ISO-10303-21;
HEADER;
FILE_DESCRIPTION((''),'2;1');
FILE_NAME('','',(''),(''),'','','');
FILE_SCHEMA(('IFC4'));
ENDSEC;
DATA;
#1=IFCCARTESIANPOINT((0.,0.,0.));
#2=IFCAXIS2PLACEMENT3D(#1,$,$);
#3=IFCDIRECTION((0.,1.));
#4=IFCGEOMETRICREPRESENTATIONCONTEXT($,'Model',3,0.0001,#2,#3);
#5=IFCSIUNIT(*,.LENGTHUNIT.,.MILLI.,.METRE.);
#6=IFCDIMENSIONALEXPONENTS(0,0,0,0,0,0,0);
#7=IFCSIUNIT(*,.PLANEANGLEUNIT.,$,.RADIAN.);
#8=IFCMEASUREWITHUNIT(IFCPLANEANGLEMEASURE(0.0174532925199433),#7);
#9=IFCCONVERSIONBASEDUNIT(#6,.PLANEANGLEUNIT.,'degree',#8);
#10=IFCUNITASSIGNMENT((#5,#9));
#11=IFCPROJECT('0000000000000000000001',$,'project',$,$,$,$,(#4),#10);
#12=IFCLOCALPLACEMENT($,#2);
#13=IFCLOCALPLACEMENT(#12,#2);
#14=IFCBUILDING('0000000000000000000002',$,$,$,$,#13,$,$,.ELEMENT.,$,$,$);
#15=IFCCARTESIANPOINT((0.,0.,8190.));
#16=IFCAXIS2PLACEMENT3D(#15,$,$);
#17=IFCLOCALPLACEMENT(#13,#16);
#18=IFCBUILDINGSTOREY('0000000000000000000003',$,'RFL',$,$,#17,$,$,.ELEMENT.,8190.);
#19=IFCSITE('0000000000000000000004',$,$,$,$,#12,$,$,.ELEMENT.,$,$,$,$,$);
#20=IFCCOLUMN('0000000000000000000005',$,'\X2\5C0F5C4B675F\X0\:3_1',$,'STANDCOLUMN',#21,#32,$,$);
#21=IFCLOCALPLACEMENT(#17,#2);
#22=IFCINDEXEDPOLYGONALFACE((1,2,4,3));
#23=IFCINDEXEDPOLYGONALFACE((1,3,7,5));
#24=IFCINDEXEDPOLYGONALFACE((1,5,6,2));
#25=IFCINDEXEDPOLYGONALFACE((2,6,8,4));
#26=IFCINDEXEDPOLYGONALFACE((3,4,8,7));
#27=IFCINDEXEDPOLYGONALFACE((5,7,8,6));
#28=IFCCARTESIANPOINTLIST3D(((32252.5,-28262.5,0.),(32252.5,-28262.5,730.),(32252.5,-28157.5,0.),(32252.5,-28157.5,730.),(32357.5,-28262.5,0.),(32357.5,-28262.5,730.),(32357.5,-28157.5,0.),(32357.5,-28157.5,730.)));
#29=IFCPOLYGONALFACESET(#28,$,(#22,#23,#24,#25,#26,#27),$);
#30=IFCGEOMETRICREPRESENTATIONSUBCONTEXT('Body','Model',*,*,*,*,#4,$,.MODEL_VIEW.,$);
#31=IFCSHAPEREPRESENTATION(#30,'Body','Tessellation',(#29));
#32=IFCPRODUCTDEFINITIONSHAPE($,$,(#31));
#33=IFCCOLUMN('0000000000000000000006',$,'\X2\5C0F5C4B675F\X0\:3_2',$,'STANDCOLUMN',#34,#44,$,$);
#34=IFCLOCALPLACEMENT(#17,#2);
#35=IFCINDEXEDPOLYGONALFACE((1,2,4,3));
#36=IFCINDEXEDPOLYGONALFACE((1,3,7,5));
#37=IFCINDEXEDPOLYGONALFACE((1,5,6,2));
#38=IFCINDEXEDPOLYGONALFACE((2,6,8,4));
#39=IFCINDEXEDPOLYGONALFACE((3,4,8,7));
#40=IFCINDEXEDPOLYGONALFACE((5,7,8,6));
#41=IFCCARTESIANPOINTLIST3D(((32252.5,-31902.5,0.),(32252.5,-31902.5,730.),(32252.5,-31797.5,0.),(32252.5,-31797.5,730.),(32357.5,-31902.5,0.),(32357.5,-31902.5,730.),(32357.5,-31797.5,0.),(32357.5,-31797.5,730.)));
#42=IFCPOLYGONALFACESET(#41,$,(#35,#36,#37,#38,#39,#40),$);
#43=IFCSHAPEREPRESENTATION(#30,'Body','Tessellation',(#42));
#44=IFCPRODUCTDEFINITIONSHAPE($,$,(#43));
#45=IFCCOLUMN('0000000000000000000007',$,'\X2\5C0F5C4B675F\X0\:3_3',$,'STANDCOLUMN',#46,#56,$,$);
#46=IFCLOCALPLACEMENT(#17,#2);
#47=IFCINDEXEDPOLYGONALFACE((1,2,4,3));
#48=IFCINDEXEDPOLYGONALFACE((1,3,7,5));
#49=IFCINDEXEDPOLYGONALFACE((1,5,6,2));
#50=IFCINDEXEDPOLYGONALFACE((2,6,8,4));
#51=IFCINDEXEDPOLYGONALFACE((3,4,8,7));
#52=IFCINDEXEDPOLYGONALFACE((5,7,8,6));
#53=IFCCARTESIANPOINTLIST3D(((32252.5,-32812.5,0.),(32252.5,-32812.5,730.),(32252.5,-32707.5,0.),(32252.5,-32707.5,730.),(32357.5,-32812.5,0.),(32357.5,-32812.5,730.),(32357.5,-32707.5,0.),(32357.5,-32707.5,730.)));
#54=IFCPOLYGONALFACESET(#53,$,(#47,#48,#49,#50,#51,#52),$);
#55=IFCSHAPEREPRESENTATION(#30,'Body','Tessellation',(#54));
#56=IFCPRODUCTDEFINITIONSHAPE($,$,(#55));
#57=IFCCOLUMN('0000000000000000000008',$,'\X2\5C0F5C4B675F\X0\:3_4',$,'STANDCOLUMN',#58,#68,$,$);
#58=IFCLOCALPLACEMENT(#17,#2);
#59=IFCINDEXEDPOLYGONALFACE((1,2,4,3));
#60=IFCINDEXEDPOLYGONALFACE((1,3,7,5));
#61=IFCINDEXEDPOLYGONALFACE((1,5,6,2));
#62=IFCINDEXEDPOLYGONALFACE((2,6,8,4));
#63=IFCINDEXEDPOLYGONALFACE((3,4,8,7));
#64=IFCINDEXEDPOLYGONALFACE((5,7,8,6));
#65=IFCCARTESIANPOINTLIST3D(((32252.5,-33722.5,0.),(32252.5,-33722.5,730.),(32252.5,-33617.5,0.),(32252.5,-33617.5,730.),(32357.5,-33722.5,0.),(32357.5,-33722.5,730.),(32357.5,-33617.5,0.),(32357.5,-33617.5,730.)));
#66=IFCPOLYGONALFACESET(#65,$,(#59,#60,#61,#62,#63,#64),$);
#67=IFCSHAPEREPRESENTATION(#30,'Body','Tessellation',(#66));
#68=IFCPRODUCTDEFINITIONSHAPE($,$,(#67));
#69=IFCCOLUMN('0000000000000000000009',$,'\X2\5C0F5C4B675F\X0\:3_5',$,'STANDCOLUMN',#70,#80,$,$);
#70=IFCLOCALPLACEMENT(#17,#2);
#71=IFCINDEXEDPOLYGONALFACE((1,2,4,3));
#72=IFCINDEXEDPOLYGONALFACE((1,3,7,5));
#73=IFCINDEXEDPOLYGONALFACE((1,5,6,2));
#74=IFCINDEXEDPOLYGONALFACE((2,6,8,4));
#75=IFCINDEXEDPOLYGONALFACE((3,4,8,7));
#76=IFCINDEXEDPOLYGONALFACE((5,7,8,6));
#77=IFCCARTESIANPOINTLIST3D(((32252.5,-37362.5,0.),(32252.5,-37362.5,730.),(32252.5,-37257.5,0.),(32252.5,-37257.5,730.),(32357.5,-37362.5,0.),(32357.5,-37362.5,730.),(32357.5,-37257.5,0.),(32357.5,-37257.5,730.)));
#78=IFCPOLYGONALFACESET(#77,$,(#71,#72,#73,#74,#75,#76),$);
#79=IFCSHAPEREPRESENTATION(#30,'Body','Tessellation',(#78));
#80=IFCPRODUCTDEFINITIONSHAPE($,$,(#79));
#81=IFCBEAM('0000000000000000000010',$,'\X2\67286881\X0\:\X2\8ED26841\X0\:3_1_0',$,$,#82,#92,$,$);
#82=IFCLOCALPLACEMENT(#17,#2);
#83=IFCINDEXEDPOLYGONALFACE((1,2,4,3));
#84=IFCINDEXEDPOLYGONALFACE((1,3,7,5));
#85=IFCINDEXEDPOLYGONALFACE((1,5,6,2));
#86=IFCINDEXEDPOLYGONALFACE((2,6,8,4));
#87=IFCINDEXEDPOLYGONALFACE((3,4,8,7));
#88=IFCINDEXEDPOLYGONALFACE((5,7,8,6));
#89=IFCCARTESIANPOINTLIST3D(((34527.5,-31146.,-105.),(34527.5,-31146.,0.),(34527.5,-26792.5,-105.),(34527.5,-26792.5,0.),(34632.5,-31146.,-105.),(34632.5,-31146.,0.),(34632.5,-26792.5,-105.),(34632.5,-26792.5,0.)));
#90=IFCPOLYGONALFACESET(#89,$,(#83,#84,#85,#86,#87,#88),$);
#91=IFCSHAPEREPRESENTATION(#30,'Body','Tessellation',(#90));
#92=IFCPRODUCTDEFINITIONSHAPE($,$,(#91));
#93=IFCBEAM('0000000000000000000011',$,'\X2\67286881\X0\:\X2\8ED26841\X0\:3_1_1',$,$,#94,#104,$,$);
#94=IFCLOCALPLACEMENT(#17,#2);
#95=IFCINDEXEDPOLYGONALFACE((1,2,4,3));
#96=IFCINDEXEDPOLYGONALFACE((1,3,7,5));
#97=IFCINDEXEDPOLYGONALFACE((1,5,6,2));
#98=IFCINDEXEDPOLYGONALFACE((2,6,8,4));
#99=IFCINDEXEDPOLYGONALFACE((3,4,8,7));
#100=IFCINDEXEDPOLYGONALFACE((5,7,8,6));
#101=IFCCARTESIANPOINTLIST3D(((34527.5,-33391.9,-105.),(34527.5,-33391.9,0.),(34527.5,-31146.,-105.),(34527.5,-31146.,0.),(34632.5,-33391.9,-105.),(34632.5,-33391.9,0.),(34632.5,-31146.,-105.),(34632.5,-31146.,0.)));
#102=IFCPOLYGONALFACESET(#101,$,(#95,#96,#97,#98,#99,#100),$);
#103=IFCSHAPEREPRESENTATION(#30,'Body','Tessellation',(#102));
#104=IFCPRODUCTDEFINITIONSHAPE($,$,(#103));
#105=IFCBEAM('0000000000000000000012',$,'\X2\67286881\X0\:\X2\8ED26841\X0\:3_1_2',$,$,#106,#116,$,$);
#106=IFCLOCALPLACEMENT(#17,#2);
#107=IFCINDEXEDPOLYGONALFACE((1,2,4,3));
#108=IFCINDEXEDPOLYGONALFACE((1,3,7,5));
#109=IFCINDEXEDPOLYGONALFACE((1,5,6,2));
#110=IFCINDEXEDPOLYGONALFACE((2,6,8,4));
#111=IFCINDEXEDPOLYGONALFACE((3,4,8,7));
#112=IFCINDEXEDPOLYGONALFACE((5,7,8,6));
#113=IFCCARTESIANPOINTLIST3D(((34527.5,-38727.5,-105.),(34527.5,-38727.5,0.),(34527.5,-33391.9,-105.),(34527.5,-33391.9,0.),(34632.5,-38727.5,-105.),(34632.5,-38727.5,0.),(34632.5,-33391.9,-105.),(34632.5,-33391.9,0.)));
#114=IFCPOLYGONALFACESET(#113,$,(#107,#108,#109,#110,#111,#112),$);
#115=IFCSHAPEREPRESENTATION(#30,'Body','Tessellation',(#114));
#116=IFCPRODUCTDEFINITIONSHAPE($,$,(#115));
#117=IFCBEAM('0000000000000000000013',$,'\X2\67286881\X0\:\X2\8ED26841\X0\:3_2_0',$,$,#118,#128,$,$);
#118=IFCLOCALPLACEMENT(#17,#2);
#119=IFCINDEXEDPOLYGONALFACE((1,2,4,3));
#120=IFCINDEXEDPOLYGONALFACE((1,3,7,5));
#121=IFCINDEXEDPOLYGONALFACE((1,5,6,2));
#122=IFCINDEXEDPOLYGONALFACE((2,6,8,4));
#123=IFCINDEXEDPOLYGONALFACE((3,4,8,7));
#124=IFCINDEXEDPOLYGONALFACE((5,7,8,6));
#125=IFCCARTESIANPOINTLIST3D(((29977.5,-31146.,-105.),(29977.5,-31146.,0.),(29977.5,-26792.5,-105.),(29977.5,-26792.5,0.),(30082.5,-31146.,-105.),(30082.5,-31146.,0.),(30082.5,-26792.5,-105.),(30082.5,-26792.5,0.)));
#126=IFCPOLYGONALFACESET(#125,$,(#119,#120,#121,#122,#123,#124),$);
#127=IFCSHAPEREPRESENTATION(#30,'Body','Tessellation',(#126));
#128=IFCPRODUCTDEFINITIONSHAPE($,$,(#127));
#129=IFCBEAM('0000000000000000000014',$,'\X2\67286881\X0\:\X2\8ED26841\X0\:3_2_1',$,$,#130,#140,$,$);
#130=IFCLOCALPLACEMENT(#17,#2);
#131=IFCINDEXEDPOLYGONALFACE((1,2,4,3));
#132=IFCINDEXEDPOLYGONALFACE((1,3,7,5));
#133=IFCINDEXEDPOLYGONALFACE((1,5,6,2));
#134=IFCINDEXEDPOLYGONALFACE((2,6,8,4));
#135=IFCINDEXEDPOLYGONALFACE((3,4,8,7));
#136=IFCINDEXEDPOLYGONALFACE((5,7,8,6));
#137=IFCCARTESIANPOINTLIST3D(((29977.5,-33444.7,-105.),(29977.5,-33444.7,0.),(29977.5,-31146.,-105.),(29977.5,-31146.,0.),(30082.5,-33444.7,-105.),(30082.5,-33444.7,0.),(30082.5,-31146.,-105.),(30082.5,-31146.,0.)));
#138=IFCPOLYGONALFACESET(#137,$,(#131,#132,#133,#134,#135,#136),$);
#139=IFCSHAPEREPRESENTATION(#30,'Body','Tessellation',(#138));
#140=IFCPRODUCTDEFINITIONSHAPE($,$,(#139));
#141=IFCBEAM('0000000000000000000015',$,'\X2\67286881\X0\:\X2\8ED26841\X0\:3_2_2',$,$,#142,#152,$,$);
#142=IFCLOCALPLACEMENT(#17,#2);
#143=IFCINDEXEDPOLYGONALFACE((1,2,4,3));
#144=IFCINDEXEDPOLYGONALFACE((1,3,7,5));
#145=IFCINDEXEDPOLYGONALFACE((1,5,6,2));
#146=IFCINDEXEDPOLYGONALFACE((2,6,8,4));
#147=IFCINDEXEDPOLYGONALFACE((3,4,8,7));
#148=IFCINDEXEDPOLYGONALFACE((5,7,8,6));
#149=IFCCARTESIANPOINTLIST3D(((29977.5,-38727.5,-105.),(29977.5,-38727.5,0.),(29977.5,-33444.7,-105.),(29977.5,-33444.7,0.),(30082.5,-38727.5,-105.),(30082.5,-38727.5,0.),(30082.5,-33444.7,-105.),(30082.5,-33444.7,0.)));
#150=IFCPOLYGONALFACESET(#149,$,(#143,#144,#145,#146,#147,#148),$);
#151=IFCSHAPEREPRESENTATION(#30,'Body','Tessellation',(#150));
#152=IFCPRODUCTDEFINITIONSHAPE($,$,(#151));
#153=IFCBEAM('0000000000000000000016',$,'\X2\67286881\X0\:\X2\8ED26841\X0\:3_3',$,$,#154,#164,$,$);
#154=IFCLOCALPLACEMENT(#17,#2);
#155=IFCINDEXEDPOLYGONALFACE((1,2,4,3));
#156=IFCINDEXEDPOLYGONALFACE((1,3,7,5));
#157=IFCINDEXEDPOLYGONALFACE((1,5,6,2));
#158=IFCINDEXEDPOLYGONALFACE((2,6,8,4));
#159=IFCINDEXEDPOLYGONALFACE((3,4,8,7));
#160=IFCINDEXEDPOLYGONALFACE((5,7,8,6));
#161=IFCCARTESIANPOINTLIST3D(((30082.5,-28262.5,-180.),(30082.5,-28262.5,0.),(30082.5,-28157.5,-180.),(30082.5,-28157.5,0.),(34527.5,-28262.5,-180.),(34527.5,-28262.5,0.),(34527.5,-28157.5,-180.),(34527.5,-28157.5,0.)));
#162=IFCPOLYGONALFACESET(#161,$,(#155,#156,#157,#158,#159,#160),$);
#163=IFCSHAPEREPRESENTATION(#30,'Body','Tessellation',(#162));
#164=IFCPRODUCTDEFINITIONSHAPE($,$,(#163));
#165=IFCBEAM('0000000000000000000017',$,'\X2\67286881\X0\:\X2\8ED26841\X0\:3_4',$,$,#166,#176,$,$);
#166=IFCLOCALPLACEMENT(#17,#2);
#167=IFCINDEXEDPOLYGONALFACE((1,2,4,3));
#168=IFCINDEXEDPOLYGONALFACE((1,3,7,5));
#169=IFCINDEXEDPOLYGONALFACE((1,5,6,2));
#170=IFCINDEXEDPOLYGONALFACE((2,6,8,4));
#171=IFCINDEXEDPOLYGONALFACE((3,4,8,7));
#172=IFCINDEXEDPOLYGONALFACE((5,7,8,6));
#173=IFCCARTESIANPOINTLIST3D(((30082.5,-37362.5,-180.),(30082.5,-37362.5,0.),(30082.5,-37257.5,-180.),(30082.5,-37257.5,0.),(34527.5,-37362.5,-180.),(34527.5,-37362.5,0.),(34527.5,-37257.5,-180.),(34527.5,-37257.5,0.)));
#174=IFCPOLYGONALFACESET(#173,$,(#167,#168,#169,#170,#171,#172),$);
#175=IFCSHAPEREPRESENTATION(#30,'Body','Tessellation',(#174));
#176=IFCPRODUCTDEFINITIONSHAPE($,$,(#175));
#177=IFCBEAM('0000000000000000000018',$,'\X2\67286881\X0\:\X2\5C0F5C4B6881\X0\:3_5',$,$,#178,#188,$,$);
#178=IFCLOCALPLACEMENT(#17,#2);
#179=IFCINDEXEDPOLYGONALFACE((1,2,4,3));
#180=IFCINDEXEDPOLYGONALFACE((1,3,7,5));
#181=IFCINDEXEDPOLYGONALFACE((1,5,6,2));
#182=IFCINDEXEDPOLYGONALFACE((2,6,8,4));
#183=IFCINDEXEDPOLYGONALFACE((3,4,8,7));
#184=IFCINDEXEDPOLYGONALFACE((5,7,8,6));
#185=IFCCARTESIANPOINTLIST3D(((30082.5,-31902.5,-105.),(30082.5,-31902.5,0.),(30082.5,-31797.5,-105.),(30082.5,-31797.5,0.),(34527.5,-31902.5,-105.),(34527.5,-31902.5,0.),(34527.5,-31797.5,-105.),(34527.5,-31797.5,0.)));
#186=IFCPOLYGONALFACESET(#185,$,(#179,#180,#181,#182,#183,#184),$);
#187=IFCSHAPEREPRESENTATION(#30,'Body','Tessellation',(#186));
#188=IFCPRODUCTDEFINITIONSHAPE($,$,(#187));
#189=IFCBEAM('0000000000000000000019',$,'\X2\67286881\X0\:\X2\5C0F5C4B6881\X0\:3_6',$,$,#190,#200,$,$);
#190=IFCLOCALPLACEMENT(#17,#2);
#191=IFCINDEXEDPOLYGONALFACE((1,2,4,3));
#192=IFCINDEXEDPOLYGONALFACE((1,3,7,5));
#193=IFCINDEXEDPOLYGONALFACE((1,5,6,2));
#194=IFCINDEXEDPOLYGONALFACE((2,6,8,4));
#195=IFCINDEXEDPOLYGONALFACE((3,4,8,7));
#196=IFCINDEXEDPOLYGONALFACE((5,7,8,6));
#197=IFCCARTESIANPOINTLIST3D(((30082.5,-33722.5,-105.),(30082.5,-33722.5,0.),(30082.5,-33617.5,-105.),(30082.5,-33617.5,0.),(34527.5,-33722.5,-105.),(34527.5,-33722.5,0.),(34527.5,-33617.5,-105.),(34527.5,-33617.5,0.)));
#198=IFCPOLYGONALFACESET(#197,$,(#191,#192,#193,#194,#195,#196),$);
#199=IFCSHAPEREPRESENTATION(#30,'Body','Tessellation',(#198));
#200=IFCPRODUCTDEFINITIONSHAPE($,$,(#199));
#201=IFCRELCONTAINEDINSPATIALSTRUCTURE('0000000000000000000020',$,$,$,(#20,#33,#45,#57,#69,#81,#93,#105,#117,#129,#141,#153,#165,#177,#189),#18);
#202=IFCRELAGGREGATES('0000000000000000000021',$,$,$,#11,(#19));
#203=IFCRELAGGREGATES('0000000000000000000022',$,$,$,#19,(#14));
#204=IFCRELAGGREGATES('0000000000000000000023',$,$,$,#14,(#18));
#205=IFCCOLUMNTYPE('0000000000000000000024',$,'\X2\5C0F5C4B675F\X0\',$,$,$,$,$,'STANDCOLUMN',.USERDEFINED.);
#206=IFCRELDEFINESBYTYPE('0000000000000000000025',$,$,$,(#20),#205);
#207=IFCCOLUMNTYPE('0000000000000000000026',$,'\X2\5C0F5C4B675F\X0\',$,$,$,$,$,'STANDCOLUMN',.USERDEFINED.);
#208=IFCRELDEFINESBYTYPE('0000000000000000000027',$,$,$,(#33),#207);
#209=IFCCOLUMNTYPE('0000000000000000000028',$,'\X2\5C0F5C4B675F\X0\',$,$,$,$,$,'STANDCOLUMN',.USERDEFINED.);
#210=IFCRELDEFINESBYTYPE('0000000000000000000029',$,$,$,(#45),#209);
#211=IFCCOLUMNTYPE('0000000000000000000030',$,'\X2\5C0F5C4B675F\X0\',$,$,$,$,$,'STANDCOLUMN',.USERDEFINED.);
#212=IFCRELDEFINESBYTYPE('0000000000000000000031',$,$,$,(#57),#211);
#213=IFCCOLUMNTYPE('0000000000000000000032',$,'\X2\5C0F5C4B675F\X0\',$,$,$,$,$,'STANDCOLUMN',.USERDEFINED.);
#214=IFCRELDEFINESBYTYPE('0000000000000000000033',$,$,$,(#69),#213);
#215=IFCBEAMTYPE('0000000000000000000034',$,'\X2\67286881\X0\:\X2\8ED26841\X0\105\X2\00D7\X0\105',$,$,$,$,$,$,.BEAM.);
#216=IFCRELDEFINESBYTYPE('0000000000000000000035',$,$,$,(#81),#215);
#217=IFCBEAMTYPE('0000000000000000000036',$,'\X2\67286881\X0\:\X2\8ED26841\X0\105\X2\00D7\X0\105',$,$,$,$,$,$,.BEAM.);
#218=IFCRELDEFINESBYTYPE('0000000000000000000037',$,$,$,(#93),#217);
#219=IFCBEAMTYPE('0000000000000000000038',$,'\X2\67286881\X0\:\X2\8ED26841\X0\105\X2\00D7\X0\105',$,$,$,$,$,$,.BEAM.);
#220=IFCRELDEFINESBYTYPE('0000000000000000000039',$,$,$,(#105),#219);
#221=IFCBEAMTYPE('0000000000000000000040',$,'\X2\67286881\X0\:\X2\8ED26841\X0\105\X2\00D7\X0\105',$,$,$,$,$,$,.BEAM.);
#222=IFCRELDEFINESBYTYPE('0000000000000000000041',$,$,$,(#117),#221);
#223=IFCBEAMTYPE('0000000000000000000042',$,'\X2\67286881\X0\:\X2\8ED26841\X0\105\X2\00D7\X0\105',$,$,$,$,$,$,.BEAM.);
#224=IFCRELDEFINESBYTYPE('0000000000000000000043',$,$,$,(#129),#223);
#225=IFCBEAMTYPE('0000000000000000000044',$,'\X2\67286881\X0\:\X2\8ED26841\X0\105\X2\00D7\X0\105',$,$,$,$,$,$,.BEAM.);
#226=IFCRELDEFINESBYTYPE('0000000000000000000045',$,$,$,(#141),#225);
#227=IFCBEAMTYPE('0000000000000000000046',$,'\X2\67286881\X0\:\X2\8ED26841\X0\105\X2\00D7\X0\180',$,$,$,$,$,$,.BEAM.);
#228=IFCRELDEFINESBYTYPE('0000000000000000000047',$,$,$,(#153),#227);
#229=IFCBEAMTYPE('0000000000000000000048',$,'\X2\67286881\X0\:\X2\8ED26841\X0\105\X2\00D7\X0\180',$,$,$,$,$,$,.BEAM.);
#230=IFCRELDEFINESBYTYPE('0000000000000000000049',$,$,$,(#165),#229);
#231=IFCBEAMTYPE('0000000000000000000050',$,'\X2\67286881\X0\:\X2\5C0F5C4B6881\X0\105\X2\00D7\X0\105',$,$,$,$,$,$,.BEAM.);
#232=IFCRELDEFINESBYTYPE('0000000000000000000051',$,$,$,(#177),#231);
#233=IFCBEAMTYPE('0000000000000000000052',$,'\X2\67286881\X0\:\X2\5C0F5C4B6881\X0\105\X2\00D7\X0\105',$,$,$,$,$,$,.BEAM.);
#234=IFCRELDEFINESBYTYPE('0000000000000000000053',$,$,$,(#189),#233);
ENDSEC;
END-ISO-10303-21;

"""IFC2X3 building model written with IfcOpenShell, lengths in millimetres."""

from ifc_helpers import new_model, entity, si_unit, converted_unit, direction, frame, origin, origin_with_axes, origin_2d, place, context, subcontext, project, spatial, rectangle, extrude, type_object, element, save


model = new_model("IFC2X3")

# Units and contexts
model_context = context("Model", 3, precision=0.0001, world=origin(), true_north=direction((0.0, 1.0)))
body_context = subcontext(model_context, "Body", "Model", "MODEL_VIEW")
ifc_project = project(units=[si_unit("LENGTHUNIT", "METRE", prefix="MILLI"), converted_unit("PLANEANGLEUNIT", "degree", entity("IfcPlaneAngleMeasure", 0.0174532925199433), si_unit("PLANEANGLEUNIT", "RADIAN"), dimensions=[0, 0, 0, 0, 0, 0, 0])], contexts=[model_context])

# Site, building, storey
site_placement = place(None, origin())
site = spatial("IfcSite", under=ifc_project, at=site_placement, CompositionType="ELEMENT")
building_placement = place(site_placement, origin())
building = spatial("IfcBuilding", under=site, at=building_placement, CompositionType="ELEMENT")
storey_placement = place(building_placement, frame((0.0, 0.0, 8190.0)))
storey = spatial("IfcBuildingStorey", under=building, at=storey_placement, Name="RFL", CompositionType="ELEMENT", Elevation=8190.0)

# Columns
column_type_1 = type_object("IfcColumnType", Name="小屋束", ElementType="STANDCOLUMN", PredefinedType="USERDEFINED")
column_1_placement = place(storey_placement, frame((32305.0, -28210.0, 0.0)))
element("IfcColumn", 1, at=column_1_placement, inside=storey, type_object=column_type_1, Name="小屋束:3_1", ObjectType="STANDCOLUMN", context=body_context, shape_type="SweptSolid", body=[
    extrude(rectangle(XDim=105.0, YDim=105.0, at=origin_2d()), origin_with_axes(), (0.0, 0.0, 1.0), 730.0),
])
column_type_2 = type_object("IfcColumnType", Name="小屋束", ElementType="STANDCOLUMN", PredefinedType="USERDEFINED")
column_2_placement = place(storey_placement, frame((32305.0, -31850.0, 0.0)))
element("IfcColumn", 2, at=column_2_placement, inside=storey, type_object=column_type_2, Name="小屋束:3_2", ObjectType="STANDCOLUMN", context=body_context, shape_type="SweptSolid", body=[
    extrude(rectangle(XDim=105.0, YDim=105.0, at=origin_2d()), origin_with_axes(), (0.0, 0.0, 1.0), 730.0),
])
column_type_3 = type_object("IfcColumnType", Name="小屋束", ElementType="STANDCOLUMN", PredefinedType="USERDEFINED")
column_3_placement = place(storey_placement, frame((32305.0, -32760.0, 0.0)))
element("IfcColumn", 3, at=column_3_placement, inside=storey, type_object=column_type_3, Name="小屋束:3_3", ObjectType="STANDCOLUMN", context=body_context, shape_type="SweptSolid", body=[
    extrude(rectangle(XDim=105.0, YDim=105.0, at=origin_2d()), origin_with_axes(), (0.0, 0.0, 1.0), 730.0),
])
column_type_4 = type_object("IfcColumnType", Name="小屋束", ElementType="STANDCOLUMN", PredefinedType="USERDEFINED")
column_4_placement = place(storey_placement, frame((32305.0, -33670.0, 0.0)))
element("IfcColumn", 4, at=column_4_placement, inside=storey, type_object=column_type_4, Name="小屋束:3_4", ObjectType="STANDCOLUMN", context=body_context, shape_type="SweptSolid", body=[
    extrude(rectangle(XDim=105.0, YDim=105.0, at=origin_2d()), origin_with_axes(), (0.0, 0.0, 1.0), 730.0),
])
column_type_5 = type_object("IfcColumnType", Name="小屋束", ElementType="STANDCOLUMN", PredefinedType="USERDEFINED")
column_5_placement = place(storey_placement, frame((32305.0, -37310.0, 0.0)))
element("IfcColumn", 5, at=column_5_placement, inside=storey, type_object=column_type_5, Name="小屋束:3_5", ObjectType="STANDCOLUMN", context=body_context, shape_type="SweptSolid", body=[
    extrude(rectangle(XDim=105.0, YDim=105.0, at=origin_2d()), origin_with_axes(), (0.0, 0.0, 1.0), 730.0),
])

# Beams
beam_type_1 = type_object("IfcBeamType", Name="木梁:軒桁105×105", PredefinedType="BEAM")
beam_1_placement = place(storey_placement, frame((34580.0, -26792.5, -52.5), z_axis=(0.0, -1.0, 0.0), x_axis=(1.0, 0.0, 0.0)))
element("IfcBeam", 6, at=beam_1_placement, inside=storey, type_object=beam_type_1, Name="木梁:軒桁:3_1_0", context=body_context, shape_type="SweptSolid", body=[
    extrude(rectangle(XDim=105.0, YDim=105.0, at=origin_2d()), origin_with_axes(), (0.0, 0.0, 1.0), 4353.5),
])
beam_type_2 = type_object("IfcBeamType", Name="木梁:軒桁105×105", PredefinedType="BEAM")
beam_2_placement = place(storey_placement, frame((34580.0, -31146.0, -52.5), z_axis=(0.0, -1.0, 0.0), x_axis=(1.0, 0.0, 0.0)))
element("IfcBeam", 7, at=beam_2_placement, inside=storey, type_object=beam_type_2, Name="木梁:軒桁:3_1_1", context=body_context, shape_type="SweptSolid", body=[
    extrude(rectangle(XDim=105.0, YDim=105.0, at=origin_2d()), origin_with_axes(), (0.0, 0.0, 1.0), 2245.9),
])
beam_type_3 = type_object("IfcBeamType", Name="木梁:軒桁105×105", PredefinedType="BEAM")
beam_3_placement = place(storey_placement, frame((34580.0, -33391.9, -52.5), z_axis=(0.0, -1.0, 0.0), x_axis=(1.0, 0.0, 0.0)))
element("IfcBeam", 8, at=beam_3_placement, inside=storey, type_object=beam_type_3, Name="木梁:軒桁:3_1_2", context=body_context, shape_type="SweptSolid", body=[
    extrude(rectangle(XDim=105.0, YDim=105.0, at=origin_2d()), origin_with_axes(), (0.0, 0.0, 1.0), 5335.6),
])
beam_type_4 = type_object("IfcBeamType", Name="木梁:軒桁105×105", PredefinedType="BEAM")
beam_4_placement = place(storey_placement, frame((30030.0, -26792.5, -52.5), z_axis=(0.0, -1.0, 0.0), x_axis=(1.0, 0.0, 0.0)))
element("IfcBeam", 9, at=beam_4_placement, inside=storey, type_object=beam_type_4, Name="木梁:軒桁:3_2_0", context=body_context, shape_type="SweptSolid", body=[
    extrude(rectangle(XDim=105.0, YDim=105.0, at=origin_2d()), origin_with_axes(), (0.0, 0.0, 1.0), 4353.5),
])
beam_type_5 = type_object("IfcBeamType", Name="木梁:軒桁105×105", PredefinedType="BEAM")
beam_5_placement = place(storey_placement, frame((30030.0, -31146.0, -52.5), z_axis=(0.0, -1.0, 0.0), x_axis=(1.0, 0.0, 0.0)))
element("IfcBeam", 10, at=beam_5_placement, inside=storey, type_object=beam_type_5, Name="木梁:軒桁:3_2_1", context=body_context, shape_type="SweptSolid", body=[
    extrude(rectangle(XDim=105.0, YDim=105.0, at=origin_2d()), origin_with_axes(), (0.0, 0.0, 1.0), 2298.7),
])
beam_type_6 = type_object("IfcBeamType", Name="木梁:軒桁105×105", PredefinedType="BEAM")
beam_6_placement = place(storey_placement, frame((30030.0, -33444.7, -52.5), z_axis=(0.0, -1.0, 0.0), x_axis=(1.0, 0.0, 0.0)))
element("IfcBeam", 11, at=beam_6_placement, inside=storey, type_object=beam_type_6, Name="木梁:軒桁:3_2_2", context=body_context, shape_type="SweptSolid", body=[
    extrude(rectangle(XDim=105.0, YDim=105.0, at=origin_2d()), origin_with_axes(), (0.0, 0.0, 1.0), 5282.8),
])
beam_type_7 = type_object("IfcBeamType", Name="木梁:軒桁105×180", PredefinedType="BEAM")
beam_7_placement = place(storey_placement, frame((30082.5, -28210.0, -90.0), z_axis=(1.0, 0.0, 0.0), x_axis=(0.0, 1.0, 0.0)))
element("IfcBeam", 12, at=beam_7_placement, inside=storey, type_object=beam_type_7, Name="木梁:軒桁:3_3", context=body_context, shape_type="SweptSolid", body=[
    extrude(rectangle(XDim=105.0, YDim=180.0, at=origin_2d()), origin_with_axes(), (0.0, 0.0, 1.0), 4445.0),
])
beam_type_8 = type_object("IfcBeamType", Name="木梁:軒桁105×180", PredefinedType="BEAM")
beam_8_placement = place(storey_placement, frame((30082.5, -37310.0, -90.0), z_axis=(1.0, 0.0, 0.0), x_axis=(0.0, 1.0, 0.0)))
element("IfcBeam", 13, at=beam_8_placement, inside=storey, type_object=beam_type_8, Name="木梁:軒桁:3_4", context=body_context, shape_type="SweptSolid", body=[
    extrude(rectangle(XDim=105.0, YDim=180.0, at=origin_2d()), origin_with_axes(), (0.0, 0.0, 1.0), 4445.0),
])
beam_type_9 = type_object("IfcBeamType", Name="木梁:小屋梁105×105", PredefinedType="BEAM")
beam_9_placement = place(storey_placement, frame((30082.5, -31850.0, -52.5), z_axis=(1.0, 0.0, 0.0), x_axis=(0.0, 1.0, 0.0)))
element("IfcBeam", 14, at=beam_9_placement, inside=storey, type_object=beam_type_9, Name="木梁:小屋梁:3_5", context=body_context, shape_type="SweptSolid", body=[
    extrude(rectangle(XDim=105.0, YDim=105.0, at=origin_2d()), origin_with_axes(), (0.0, 0.0, 1.0), 4445.0),
])
beam_type_10 = type_object("IfcBeamType", Name="木梁:小屋梁105×105", PredefinedType="BEAM")
beam_10_placement = place(storey_placement, frame((30082.5, -33670.0, -52.5), z_axis=(1.0, 0.0, 0.0), x_axis=(0.0, 1.0, 0.0)))
element("IfcBeam", 15, at=beam_10_placement, inside=storey, type_object=beam_type_10, Name="木梁:小屋梁:3_6", context=body_context, shape_type="SweptSolid", body=[
    extrude(rectangle(XDim=105.0, YDim=105.0, at=origin_2d()), origin_with_axes(), (0.0, 0.0, 1.0), 4445.0),
])

save(model, "model.ifc")
